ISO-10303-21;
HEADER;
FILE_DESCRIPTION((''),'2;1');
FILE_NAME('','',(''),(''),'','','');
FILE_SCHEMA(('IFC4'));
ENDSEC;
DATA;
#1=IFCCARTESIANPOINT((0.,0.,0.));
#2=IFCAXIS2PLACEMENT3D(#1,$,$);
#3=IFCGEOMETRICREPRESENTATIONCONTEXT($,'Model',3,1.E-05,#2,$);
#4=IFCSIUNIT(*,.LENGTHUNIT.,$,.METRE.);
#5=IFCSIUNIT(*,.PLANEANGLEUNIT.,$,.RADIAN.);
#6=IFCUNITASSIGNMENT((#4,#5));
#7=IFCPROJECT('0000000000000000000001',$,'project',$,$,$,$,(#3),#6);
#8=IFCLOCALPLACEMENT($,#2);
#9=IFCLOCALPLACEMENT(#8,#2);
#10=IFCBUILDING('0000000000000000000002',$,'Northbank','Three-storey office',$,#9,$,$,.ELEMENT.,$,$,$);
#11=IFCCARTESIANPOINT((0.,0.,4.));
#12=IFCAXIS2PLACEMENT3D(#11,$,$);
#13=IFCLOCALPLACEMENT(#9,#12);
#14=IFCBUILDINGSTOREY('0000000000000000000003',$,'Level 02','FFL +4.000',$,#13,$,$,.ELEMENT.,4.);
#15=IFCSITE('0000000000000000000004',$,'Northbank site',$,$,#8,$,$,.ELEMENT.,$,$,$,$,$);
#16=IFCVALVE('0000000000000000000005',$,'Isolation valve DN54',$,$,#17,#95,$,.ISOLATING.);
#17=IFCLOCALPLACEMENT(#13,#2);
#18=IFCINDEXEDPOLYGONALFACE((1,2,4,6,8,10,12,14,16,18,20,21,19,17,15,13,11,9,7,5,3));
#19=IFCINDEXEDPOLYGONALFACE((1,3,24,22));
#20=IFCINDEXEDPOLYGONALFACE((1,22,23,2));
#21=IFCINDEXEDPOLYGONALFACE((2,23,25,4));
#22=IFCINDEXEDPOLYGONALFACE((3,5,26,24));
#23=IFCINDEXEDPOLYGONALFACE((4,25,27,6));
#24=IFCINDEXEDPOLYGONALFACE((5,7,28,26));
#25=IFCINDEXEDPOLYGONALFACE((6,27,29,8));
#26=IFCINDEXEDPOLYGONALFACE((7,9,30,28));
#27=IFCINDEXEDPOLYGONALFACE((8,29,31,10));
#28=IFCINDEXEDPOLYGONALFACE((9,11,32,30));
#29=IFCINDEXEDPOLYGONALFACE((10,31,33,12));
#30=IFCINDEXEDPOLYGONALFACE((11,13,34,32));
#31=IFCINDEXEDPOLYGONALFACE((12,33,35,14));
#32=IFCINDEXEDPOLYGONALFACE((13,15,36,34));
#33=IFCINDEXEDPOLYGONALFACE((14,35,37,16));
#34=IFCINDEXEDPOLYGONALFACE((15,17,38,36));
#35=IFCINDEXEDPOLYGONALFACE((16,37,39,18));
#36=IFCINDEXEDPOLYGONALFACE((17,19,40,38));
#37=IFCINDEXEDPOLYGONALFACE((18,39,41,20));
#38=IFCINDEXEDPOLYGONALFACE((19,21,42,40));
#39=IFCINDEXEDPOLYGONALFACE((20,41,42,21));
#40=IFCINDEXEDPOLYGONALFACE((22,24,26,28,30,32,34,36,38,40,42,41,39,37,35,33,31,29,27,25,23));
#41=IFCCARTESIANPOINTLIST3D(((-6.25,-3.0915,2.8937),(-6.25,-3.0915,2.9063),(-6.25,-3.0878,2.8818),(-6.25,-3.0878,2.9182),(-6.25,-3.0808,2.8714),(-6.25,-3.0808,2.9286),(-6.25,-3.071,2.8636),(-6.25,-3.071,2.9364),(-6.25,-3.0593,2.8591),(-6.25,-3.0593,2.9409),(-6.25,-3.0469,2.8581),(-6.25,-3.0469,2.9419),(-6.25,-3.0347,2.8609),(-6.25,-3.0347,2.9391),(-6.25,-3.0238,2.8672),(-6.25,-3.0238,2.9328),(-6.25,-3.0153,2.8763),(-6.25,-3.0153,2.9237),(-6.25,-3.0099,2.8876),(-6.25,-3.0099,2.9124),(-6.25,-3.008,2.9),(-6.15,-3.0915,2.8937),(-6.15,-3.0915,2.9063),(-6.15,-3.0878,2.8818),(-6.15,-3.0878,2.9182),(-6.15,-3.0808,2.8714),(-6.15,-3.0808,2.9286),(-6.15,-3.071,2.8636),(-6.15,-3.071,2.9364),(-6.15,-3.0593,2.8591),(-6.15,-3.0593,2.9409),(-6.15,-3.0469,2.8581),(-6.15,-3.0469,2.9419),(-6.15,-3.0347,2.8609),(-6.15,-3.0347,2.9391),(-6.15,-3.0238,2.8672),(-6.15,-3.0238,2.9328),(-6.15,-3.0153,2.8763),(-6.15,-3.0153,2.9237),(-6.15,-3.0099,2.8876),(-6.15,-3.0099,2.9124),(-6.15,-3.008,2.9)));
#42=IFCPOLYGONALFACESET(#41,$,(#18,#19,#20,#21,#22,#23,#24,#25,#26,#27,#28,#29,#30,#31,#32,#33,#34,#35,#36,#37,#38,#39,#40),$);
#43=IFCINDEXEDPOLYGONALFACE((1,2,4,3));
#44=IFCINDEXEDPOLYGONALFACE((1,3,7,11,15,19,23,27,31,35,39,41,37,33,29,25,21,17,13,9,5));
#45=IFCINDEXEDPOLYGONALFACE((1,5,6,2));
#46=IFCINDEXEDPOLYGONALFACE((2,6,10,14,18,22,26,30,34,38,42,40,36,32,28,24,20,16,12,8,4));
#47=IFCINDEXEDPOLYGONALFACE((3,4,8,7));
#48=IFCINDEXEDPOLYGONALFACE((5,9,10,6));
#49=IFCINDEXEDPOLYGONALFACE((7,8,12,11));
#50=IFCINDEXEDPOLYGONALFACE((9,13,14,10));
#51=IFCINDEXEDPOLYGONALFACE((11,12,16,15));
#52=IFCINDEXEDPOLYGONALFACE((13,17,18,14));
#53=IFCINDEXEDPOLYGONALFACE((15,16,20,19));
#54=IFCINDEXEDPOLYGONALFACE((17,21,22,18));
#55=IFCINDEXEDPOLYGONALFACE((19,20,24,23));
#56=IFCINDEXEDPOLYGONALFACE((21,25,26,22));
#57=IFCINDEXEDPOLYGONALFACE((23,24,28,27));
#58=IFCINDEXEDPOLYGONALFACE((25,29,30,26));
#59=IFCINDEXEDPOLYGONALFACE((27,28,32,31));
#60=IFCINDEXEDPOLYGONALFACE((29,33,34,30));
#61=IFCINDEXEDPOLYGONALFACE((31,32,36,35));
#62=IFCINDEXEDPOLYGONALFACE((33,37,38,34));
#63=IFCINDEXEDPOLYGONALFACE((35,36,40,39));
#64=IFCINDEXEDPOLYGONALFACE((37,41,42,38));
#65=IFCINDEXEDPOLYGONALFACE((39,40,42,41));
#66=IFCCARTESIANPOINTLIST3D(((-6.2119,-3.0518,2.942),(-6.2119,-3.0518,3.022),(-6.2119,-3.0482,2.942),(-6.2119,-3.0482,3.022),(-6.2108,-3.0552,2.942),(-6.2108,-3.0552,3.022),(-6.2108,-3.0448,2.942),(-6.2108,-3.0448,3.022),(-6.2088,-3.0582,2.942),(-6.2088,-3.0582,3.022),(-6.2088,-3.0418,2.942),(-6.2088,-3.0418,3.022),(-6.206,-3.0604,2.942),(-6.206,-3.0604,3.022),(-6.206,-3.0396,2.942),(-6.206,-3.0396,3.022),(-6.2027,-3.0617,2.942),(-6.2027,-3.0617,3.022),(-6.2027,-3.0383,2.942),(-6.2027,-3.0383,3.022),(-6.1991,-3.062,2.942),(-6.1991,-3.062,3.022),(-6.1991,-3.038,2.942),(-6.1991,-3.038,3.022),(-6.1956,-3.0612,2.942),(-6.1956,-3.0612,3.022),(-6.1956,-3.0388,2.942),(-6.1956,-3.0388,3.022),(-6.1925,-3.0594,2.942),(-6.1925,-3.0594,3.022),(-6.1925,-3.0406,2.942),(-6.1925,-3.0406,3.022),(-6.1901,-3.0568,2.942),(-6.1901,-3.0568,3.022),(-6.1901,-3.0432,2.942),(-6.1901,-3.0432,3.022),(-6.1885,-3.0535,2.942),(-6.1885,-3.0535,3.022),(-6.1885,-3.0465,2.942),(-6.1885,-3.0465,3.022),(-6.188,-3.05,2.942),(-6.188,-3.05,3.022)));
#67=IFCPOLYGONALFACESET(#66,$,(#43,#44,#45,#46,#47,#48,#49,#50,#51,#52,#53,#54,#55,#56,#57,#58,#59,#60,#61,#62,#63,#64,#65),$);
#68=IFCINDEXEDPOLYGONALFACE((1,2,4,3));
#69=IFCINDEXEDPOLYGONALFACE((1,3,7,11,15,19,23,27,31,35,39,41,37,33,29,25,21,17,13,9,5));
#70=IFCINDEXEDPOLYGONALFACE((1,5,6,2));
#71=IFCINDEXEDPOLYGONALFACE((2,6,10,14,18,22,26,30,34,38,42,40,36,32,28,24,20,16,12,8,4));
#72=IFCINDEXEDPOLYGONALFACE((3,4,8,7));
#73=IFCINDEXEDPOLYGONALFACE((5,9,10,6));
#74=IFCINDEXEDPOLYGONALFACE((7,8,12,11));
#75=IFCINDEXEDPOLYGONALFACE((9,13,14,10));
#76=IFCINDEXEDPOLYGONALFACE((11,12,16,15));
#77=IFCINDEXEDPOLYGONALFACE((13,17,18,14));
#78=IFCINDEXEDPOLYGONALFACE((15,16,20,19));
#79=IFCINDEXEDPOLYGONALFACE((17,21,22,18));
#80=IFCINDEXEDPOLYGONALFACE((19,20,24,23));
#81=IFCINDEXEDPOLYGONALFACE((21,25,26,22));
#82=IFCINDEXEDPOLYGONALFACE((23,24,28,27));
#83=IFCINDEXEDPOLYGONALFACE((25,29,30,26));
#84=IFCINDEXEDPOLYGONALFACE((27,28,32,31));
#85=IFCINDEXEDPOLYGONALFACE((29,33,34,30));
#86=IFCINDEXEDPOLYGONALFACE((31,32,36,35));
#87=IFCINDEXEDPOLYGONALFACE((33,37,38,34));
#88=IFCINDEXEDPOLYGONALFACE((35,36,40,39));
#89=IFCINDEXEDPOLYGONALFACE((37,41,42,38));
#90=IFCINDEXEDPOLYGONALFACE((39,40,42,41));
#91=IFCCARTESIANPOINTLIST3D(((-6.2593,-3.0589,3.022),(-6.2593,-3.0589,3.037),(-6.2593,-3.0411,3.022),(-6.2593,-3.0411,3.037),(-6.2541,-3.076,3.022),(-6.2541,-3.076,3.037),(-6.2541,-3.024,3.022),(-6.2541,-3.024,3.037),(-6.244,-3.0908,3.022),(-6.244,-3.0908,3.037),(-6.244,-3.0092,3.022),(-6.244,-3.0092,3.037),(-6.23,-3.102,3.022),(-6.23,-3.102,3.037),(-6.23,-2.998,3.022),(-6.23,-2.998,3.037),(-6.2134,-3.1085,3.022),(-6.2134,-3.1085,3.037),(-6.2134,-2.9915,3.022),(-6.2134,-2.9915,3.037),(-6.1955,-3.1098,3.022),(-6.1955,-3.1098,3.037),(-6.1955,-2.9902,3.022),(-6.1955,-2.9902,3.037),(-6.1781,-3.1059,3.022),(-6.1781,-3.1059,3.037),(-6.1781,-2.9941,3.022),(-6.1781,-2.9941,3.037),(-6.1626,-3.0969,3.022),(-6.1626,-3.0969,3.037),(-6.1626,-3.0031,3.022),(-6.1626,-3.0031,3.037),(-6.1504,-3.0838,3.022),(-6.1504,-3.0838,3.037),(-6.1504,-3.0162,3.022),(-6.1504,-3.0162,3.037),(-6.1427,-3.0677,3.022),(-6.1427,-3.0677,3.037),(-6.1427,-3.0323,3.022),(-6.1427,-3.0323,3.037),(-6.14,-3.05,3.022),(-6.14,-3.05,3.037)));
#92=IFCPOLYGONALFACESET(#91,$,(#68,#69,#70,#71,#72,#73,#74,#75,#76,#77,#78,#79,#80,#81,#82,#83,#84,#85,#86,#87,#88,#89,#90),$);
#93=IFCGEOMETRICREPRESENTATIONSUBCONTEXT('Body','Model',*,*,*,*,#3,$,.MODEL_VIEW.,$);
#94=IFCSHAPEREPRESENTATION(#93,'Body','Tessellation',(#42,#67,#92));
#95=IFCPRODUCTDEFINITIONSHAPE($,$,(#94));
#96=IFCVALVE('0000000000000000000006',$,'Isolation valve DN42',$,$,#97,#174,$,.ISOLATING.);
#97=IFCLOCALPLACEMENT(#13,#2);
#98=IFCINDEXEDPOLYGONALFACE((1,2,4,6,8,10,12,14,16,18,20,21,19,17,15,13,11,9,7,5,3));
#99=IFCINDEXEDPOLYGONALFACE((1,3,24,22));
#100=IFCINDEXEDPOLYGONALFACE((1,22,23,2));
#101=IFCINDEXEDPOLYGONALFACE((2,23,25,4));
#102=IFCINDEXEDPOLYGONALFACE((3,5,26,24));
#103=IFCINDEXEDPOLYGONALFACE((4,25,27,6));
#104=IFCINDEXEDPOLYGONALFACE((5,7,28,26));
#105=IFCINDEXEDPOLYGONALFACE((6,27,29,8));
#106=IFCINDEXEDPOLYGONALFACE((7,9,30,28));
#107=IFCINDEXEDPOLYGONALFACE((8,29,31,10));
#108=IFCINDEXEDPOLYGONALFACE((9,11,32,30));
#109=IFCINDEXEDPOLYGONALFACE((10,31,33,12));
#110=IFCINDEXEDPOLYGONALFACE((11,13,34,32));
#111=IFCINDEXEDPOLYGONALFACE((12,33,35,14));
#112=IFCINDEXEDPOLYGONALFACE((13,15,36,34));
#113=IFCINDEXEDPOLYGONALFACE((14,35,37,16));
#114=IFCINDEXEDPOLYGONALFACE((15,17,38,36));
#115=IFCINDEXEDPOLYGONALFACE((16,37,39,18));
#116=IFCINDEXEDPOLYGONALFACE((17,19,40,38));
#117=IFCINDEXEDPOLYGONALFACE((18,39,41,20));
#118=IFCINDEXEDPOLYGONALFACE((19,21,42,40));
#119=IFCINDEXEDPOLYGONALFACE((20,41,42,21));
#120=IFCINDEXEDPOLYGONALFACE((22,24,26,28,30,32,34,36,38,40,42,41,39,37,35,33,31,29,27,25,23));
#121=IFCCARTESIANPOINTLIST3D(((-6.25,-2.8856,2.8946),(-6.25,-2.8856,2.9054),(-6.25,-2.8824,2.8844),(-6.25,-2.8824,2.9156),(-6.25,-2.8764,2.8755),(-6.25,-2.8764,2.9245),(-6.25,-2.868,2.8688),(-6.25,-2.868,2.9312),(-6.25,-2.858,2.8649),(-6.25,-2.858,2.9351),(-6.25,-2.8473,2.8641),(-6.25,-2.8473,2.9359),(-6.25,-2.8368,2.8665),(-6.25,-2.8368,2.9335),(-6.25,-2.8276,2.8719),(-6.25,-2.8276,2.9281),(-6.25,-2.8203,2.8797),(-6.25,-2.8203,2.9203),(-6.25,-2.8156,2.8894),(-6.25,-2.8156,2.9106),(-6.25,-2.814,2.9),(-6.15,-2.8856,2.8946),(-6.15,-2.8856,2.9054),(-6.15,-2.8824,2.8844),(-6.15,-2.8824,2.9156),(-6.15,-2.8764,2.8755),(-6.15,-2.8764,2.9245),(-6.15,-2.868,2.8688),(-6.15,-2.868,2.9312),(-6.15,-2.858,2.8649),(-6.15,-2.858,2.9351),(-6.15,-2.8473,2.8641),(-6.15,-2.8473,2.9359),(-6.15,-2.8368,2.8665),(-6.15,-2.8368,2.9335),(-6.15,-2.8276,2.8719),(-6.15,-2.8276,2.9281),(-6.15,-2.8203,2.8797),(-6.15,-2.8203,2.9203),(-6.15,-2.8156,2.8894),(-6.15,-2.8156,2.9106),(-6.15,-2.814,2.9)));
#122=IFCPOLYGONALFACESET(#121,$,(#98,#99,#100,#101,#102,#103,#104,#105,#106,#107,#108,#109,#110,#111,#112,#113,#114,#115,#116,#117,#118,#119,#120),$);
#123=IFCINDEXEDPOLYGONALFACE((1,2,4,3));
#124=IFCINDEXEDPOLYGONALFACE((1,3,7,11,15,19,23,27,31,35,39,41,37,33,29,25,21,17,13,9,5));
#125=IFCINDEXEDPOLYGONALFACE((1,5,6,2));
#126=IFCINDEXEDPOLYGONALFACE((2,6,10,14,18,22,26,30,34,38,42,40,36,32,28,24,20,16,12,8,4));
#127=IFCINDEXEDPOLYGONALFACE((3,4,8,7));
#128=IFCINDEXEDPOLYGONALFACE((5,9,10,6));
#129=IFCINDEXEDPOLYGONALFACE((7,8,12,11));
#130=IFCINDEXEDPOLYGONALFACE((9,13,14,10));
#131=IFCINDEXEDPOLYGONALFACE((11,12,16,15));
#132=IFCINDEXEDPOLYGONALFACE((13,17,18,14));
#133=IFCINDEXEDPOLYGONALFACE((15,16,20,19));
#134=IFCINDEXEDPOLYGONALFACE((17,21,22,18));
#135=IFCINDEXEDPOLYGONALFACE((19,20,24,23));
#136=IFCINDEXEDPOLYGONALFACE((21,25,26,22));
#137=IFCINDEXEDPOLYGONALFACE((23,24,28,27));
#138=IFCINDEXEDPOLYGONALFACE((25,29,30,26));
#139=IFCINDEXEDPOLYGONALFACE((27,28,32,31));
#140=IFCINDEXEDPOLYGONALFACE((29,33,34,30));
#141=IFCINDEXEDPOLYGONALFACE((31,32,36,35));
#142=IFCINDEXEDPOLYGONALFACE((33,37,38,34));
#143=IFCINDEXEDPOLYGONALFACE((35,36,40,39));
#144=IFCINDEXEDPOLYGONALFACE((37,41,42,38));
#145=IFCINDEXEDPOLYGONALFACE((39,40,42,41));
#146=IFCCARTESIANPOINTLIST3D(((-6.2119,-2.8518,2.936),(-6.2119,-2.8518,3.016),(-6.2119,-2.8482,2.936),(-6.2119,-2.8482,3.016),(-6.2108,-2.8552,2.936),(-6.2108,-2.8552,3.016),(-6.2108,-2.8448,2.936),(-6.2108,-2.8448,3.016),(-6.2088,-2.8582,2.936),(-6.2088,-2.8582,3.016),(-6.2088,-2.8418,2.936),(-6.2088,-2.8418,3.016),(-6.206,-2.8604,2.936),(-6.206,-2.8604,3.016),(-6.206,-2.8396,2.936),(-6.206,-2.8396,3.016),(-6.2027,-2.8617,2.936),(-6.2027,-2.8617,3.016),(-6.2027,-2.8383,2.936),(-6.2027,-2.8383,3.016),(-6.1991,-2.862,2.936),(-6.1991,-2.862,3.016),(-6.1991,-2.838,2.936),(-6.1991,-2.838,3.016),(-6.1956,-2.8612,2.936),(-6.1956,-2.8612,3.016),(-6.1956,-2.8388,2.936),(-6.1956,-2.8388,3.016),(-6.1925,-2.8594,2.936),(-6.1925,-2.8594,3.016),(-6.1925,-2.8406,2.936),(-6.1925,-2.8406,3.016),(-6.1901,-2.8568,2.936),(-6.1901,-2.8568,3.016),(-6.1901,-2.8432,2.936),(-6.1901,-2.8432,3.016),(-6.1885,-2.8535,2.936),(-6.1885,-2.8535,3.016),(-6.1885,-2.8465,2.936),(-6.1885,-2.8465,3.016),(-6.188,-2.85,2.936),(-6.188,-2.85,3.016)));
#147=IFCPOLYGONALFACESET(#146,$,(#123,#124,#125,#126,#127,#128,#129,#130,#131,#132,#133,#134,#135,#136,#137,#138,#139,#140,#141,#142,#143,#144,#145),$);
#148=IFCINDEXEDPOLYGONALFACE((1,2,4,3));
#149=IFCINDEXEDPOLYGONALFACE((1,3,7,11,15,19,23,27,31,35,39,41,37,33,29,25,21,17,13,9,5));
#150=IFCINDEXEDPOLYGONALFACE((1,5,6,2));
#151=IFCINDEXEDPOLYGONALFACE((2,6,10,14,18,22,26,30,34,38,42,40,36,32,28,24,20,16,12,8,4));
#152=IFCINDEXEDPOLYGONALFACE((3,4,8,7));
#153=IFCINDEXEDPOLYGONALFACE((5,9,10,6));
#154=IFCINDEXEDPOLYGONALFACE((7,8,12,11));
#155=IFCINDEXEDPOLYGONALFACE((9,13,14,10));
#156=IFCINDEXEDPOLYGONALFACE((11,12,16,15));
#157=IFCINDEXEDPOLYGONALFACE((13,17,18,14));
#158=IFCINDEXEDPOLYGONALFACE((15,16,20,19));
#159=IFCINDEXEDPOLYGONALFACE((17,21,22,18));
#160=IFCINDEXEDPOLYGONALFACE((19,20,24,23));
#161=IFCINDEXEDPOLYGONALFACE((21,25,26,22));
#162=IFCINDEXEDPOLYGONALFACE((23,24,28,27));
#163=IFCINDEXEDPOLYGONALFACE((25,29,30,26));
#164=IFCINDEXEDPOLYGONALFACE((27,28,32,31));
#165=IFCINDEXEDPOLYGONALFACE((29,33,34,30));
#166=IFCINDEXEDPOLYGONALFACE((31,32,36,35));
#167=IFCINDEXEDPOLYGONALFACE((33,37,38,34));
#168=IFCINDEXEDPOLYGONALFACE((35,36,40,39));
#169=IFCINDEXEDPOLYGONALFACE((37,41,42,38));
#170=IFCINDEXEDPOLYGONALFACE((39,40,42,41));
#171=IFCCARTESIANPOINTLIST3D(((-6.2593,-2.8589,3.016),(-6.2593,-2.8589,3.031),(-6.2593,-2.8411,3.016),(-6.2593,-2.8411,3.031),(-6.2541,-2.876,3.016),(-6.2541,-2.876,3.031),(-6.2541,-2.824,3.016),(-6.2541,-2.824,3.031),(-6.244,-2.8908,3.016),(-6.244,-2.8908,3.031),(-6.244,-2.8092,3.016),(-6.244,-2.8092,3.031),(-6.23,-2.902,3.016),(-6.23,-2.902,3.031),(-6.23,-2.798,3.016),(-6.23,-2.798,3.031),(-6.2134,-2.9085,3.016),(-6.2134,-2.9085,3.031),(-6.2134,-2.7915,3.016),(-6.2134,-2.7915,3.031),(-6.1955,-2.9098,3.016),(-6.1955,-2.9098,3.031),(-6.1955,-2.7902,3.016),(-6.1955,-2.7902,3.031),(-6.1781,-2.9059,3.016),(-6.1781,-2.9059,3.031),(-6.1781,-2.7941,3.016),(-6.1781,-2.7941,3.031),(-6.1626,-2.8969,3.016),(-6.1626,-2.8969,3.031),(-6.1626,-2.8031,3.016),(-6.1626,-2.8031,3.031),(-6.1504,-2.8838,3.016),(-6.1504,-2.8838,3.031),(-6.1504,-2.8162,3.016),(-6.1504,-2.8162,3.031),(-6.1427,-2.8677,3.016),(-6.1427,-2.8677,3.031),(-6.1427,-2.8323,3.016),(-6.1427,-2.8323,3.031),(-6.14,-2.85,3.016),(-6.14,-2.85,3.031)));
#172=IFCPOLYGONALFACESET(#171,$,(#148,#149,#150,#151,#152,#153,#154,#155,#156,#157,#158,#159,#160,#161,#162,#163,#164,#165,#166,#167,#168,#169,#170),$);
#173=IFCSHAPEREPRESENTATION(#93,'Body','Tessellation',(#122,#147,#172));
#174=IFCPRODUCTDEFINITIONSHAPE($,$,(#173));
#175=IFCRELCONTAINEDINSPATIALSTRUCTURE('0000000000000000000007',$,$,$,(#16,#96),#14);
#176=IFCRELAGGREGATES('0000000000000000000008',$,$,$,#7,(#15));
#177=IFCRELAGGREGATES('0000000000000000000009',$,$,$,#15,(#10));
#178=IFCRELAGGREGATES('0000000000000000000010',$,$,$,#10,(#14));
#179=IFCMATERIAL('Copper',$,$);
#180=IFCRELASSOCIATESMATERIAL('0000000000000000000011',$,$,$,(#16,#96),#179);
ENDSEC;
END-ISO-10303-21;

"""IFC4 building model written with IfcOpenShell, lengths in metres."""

from ifc_helpers import new_model, si_unit, frame, origin, place, context, subcontext, project, spatial, circle, extrude, material, element, save


model = new_model("IFC4")

# Units and contexts
model_context = context("Model", 3, precision=1e-05, world=origin())
body_context = subcontext(model_context, "Body", "Model", "MODEL_VIEW")
ifc_project = project(units=[si_unit("LENGTHUNIT", "METRE"), si_unit("PLANEANGLEUNIT", "RADIAN")], contexts=[model_context])

# Site, building, storey
site_placement = place(None, origin())
site = spatial("IfcSite", under=ifc_project, at=site_placement, Name="Northbank site", CompositionType="ELEMENT")
building_placement = place(site_placement, origin())
building = spatial("IfcBuilding", under=site, at=building_placement, Name="Northbank", Description="Three-storey office", CompositionType="ELEMENT")
storey_placement = place(building_placement, frame((0.0, 0.0, 4.0)))
storey = spatial("IfcBuildingStorey", under=building, at=storey_placement, Name="Level 02", Description="FFL +4.000", CompositionType="ELEMENT", Elevation=4.0)

# Shared definitions
ifc_material = material(Name="Copper")

# Valve
valve_1_placement = place(storey_placement, frame((0.0, 0.0, -4.0)))
element("IfcValve", 1, at=valve_1_placement, inside=storey, material=ifc_material, Name="Isolation valve DN54", PredefinedType="ISOLATING", context=body_context, shape_type="SweptSolid", body=[
    extrude(circle(Radius=0.042), frame((-6.25, -3.05, 6.9), z_axis=(1.0, 0.0, 0.0), x_axis=(0.0, 1.0, 0.0)), (0.0, 0.0, 1.0), 0.1),
    extrude(circle(Radius=0.012), frame((-6.2, -3.05, 6.942), z_axis=(0.0, 0.0, 1.0), x_axis=(1.0, 0.0, 0.0)), (0.0, 0.0, 1.0), 0.08),
    extrude(circle(Radius=0.06), frame((-6.2, -3.05, 7.022), z_axis=(0.0, 0.0, 1.0), x_axis=(1.0, 0.0, 0.0)), (0.0, 0.0, 1.0), 0.015),
])

# Valve
valve_2_placement = place(storey_placement, frame((0.0, 0.0, -4.0)))
element("IfcValve", 2, at=valve_2_placement, inside=storey, material=ifc_material, Name="Isolation valve DN42", PredefinedType="ISOLATING", context=body_context, shape_type="SweptSolid", body=[
    extrude(circle(Radius=0.036), frame((-6.25, -2.85, 6.9), z_axis=(1.0, 0.0, 0.0), x_axis=(0.0, 1.0, 0.0)), (0.0, 0.0, 1.0), 0.1),
    extrude(circle(Radius=0.012), frame((-6.2, -2.85, 6.936), z_axis=(0.0, 0.0, 1.0), x_axis=(1.0, 0.0, 0.0)), (0.0, 0.0, 1.0), 0.08),
    extrude(circle(Radius=0.06), frame((-6.2, -2.85, 7.016), z_axis=(0.0, 0.0, 1.0), x_axis=(1.0, 0.0, 0.0)), (0.0, 0.0, 1.0), 0.015),
])

save(model, "model.ifc")
